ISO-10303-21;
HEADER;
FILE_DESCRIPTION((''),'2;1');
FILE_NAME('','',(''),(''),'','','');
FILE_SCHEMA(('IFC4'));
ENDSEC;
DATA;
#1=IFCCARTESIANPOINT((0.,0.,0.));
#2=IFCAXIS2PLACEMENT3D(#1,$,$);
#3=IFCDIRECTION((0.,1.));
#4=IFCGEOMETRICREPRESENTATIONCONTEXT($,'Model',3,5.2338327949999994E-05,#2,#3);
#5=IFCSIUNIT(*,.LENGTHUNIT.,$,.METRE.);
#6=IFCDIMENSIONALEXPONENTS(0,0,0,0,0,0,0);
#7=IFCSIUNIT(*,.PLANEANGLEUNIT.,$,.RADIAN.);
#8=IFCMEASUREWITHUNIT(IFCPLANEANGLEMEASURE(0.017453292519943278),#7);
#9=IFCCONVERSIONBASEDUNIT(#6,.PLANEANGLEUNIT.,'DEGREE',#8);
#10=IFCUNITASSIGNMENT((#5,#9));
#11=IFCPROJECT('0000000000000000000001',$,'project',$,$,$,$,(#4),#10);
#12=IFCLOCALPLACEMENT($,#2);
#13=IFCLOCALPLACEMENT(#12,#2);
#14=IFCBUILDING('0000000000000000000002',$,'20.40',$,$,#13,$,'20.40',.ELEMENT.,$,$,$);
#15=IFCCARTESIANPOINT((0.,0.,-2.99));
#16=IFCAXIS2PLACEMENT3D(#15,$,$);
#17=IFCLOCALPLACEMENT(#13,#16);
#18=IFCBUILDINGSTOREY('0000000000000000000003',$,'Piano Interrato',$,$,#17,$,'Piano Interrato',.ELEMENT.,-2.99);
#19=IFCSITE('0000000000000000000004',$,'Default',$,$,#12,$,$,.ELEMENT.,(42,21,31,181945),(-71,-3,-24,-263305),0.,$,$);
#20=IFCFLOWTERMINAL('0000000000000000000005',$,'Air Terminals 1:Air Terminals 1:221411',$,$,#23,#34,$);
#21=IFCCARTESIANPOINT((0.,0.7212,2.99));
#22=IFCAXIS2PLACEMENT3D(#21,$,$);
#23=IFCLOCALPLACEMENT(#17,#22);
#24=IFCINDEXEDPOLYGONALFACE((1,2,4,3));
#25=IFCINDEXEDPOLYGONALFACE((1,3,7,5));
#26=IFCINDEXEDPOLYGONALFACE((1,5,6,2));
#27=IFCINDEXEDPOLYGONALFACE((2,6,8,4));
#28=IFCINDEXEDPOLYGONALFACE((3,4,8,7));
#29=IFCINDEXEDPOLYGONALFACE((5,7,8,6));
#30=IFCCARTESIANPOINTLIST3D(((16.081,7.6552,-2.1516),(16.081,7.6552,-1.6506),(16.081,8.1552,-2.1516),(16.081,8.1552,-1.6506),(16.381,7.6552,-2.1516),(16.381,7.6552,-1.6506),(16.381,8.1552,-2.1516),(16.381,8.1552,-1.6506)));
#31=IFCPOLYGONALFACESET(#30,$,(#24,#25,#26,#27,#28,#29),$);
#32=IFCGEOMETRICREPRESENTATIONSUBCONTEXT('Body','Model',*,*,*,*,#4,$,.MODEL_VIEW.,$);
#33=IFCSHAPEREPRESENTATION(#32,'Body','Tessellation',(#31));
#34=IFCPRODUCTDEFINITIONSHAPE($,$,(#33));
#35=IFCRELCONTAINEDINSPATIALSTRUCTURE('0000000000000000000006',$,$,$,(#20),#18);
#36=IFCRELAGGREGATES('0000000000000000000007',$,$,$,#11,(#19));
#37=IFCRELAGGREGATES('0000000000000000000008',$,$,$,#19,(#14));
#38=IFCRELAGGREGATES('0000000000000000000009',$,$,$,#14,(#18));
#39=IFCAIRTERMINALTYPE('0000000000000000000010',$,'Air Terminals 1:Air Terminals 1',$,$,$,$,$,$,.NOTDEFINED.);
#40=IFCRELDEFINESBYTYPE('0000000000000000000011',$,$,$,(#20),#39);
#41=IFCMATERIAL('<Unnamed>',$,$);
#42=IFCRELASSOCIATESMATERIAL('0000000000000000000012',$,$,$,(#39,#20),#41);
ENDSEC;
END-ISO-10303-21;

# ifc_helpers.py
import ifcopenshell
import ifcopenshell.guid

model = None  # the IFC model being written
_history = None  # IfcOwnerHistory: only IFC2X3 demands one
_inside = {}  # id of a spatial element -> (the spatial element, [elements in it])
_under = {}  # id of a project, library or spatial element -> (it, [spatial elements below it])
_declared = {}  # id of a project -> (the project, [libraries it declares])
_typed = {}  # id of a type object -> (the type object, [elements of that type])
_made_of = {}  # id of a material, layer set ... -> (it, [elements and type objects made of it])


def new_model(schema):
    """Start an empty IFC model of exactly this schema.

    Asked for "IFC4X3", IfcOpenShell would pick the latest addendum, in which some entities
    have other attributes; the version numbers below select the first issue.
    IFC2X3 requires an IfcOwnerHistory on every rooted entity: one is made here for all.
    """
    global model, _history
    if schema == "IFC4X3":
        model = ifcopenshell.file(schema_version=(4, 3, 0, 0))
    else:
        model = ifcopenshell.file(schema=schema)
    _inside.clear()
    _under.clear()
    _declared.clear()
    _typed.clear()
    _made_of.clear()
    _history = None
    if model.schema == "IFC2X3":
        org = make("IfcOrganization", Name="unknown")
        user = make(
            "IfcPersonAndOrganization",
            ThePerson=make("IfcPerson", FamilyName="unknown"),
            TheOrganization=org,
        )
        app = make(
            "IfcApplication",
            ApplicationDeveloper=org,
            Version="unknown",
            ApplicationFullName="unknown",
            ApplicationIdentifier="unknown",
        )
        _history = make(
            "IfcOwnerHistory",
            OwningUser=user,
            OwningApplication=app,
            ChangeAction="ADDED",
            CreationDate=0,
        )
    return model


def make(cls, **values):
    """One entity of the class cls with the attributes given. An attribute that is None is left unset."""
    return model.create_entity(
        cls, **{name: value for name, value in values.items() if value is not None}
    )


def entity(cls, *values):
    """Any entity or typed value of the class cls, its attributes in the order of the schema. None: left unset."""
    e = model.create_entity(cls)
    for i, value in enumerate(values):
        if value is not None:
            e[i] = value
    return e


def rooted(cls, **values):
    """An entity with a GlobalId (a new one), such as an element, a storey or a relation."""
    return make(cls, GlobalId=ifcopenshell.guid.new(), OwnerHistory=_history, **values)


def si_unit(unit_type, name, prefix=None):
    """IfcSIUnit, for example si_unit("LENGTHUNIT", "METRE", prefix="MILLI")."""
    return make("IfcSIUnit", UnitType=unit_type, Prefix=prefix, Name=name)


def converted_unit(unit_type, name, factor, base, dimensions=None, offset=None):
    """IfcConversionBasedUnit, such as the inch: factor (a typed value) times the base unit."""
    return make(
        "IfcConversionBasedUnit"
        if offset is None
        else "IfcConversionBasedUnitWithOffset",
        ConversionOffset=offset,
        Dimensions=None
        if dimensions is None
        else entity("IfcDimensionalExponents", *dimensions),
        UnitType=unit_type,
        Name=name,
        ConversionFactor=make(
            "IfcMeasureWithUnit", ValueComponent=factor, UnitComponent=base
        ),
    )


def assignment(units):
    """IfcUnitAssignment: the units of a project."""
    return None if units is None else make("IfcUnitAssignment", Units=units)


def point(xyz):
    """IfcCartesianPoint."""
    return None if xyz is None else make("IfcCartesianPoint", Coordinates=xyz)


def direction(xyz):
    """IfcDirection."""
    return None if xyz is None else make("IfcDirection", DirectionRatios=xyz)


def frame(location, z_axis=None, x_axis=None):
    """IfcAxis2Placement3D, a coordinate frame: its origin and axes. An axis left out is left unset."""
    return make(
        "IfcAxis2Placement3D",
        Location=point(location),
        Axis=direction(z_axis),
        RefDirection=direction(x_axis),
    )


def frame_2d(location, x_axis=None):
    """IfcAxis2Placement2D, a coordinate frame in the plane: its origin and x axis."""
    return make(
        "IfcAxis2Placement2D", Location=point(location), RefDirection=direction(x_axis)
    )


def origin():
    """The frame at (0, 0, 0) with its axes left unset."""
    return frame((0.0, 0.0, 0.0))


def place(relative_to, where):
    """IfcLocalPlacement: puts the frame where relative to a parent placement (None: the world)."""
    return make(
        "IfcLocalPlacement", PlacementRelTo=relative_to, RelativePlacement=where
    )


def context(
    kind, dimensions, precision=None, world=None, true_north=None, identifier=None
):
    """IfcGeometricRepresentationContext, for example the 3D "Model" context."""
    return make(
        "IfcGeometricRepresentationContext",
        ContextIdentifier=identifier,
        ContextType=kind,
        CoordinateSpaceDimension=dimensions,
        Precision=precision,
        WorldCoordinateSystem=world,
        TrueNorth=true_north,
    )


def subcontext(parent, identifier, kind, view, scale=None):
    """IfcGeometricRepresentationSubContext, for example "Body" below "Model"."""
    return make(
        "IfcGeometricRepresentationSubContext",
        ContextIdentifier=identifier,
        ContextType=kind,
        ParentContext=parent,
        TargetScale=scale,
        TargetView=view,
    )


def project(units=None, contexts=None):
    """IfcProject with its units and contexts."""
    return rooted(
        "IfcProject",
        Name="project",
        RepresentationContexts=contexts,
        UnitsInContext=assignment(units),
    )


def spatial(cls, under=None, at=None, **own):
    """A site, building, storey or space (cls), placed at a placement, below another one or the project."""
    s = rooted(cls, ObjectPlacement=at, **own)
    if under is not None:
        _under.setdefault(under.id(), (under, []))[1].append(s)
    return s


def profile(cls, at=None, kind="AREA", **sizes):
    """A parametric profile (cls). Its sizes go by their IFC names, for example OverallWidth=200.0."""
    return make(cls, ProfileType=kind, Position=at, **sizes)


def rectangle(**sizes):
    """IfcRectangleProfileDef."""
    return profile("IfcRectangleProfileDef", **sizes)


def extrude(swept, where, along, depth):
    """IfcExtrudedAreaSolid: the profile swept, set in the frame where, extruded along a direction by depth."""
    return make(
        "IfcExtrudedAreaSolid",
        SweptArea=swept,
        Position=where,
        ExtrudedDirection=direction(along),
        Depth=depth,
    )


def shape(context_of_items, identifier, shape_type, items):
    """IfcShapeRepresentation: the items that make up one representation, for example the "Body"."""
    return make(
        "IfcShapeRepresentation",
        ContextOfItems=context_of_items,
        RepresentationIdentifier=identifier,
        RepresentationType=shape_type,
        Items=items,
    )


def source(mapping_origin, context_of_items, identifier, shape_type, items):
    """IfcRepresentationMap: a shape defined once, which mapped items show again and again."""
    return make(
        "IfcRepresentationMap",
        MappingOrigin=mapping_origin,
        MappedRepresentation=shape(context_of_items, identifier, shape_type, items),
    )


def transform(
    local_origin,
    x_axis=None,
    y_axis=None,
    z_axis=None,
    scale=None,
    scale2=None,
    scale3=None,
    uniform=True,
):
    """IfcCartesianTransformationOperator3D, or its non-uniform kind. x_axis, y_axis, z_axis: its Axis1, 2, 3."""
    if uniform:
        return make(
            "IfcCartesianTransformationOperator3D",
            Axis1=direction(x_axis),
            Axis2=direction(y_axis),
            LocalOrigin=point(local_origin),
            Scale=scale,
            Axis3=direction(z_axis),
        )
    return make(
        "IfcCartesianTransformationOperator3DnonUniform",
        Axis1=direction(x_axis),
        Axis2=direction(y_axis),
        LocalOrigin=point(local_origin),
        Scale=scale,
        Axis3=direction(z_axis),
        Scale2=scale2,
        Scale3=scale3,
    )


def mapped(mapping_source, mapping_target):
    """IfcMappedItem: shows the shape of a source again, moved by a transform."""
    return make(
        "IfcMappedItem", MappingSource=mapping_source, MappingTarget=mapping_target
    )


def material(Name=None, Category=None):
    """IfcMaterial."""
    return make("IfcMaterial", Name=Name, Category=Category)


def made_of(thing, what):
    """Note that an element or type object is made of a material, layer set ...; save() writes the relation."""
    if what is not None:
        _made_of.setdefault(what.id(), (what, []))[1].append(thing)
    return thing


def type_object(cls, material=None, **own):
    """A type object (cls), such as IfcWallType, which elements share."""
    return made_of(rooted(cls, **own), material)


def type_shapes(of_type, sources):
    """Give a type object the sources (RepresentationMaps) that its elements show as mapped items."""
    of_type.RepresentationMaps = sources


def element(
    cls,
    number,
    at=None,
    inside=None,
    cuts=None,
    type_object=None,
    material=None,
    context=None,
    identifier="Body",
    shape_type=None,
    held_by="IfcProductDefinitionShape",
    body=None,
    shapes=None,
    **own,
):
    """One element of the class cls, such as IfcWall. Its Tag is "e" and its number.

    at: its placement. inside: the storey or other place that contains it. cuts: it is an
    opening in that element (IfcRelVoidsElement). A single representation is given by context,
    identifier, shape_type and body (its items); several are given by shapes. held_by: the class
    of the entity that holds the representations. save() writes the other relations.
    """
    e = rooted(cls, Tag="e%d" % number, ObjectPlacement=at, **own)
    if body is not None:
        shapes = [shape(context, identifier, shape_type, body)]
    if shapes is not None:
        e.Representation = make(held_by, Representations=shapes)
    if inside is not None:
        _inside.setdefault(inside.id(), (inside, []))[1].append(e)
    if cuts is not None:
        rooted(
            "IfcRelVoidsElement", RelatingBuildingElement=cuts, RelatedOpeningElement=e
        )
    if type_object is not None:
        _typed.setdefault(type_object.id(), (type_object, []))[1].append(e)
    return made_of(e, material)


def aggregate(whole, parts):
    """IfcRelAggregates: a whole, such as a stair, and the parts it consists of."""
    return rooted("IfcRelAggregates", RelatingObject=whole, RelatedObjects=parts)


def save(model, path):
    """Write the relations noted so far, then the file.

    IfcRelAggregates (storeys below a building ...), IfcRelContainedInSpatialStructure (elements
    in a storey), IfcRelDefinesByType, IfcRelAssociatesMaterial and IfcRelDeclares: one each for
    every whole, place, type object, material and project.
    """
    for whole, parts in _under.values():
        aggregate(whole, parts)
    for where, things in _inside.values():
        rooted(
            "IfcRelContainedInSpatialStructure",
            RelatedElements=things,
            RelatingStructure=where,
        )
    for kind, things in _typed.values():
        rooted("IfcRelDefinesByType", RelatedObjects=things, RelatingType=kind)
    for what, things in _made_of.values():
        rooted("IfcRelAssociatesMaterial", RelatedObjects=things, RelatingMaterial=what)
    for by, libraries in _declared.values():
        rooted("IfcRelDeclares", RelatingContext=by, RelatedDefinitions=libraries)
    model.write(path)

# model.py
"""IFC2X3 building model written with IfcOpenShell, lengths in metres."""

from ifc_helpers import new_model, entity, si_unit, converted_unit, direction, frame, frame_2d, origin, place, context, subcontext, project, spatial, rectangle, extrude, source, transform, mapped, material, type_object, type_shapes, element, save


model = new_model("IFC2X3")

# Units and contexts
model_context = context("Model", 3, precision=5.2338327949999994e-05, world=origin(), true_north=direction((0.0, 1.0)))
body_context = subcontext(model_context, "Body", "Model", "MODEL_VIEW")
ifc_project = project(units=[si_unit("LENGTHUNIT", "METRE"), converted_unit("PLANEANGLEUNIT", "DEGREE", entity("IfcPlaneAngleMeasure", 0.017453292519943278), si_unit("PLANEANGLEUNIT", "RADIAN"), dimensions=[0, 0, 0, 0, 0, 0, 0])], contexts=[model_context])

# Site, building, storey
site_placement = place(None, origin())
site = spatial("IfcSite", under=ifc_project, at=site_placement, Name="Default", CompositionType="ELEMENT", RefLatitude=(42, 21, 31, 181945), RefLongitude=(-71, -3, -24, -263305), RefElevation=0.0)
building_placement = place(site_placement, origin())
building = spatial("IfcBuilding", under=site, at=building_placement, Name="20.40", LongName="20.40", CompositionType="ELEMENT")
storey_placement = place(building_placement, frame((0.0, 0.0, -2.99)))
storey = spatial("IfcBuildingStorey", under=building, at=storey_placement, Name="Piano Interrato", LongName="Piano Interrato", CompositionType="ELEMENT", Elevation=-2.99)

# Flow terminal
ifc_material_1 = material(Name="<Unnamed>")
air_terminal_type = type_object("IfcAirTerminalType", Name="Air Terminals 1:Air Terminals 1", PredefinedType="NOTDEFINED", material=ifc_material_1)
shared_shape = source(origin(), body_context, "Body", "SweptSolid", [
    extrude(rectangle(XDim=0.3, YDim=0.5, at=frame_2d((0.0, 0.0), x_axis=(1.0, 0.0))), frame((16.231, 7.9052, -2.1516), z_axis=(0.0, 0.0, 1.0), x_axis=(-1.0, 0.0, 0.0)), (0.0, 0.0, 1.0), 0.501),
])
type_shapes(air_terminal_type, [shared_shape])
flow_terminal_placement = place(storey_placement, frame((0.0, 0.7212, 2.99)))
element("IfcFlowTerminal", 1, at=flow_terminal_placement, inside=storey, type_object=air_terminal_type, material=ifc_material_1, Name="Air Terminals 1:Air Terminals 1:221411", context=body_context, shape_type="MappedRepresentation", body=[
    mapped(shared_shape, transform((0.0, 0.0, 0.0), scale=1.0)),
])

save(model, "model.ifc")
